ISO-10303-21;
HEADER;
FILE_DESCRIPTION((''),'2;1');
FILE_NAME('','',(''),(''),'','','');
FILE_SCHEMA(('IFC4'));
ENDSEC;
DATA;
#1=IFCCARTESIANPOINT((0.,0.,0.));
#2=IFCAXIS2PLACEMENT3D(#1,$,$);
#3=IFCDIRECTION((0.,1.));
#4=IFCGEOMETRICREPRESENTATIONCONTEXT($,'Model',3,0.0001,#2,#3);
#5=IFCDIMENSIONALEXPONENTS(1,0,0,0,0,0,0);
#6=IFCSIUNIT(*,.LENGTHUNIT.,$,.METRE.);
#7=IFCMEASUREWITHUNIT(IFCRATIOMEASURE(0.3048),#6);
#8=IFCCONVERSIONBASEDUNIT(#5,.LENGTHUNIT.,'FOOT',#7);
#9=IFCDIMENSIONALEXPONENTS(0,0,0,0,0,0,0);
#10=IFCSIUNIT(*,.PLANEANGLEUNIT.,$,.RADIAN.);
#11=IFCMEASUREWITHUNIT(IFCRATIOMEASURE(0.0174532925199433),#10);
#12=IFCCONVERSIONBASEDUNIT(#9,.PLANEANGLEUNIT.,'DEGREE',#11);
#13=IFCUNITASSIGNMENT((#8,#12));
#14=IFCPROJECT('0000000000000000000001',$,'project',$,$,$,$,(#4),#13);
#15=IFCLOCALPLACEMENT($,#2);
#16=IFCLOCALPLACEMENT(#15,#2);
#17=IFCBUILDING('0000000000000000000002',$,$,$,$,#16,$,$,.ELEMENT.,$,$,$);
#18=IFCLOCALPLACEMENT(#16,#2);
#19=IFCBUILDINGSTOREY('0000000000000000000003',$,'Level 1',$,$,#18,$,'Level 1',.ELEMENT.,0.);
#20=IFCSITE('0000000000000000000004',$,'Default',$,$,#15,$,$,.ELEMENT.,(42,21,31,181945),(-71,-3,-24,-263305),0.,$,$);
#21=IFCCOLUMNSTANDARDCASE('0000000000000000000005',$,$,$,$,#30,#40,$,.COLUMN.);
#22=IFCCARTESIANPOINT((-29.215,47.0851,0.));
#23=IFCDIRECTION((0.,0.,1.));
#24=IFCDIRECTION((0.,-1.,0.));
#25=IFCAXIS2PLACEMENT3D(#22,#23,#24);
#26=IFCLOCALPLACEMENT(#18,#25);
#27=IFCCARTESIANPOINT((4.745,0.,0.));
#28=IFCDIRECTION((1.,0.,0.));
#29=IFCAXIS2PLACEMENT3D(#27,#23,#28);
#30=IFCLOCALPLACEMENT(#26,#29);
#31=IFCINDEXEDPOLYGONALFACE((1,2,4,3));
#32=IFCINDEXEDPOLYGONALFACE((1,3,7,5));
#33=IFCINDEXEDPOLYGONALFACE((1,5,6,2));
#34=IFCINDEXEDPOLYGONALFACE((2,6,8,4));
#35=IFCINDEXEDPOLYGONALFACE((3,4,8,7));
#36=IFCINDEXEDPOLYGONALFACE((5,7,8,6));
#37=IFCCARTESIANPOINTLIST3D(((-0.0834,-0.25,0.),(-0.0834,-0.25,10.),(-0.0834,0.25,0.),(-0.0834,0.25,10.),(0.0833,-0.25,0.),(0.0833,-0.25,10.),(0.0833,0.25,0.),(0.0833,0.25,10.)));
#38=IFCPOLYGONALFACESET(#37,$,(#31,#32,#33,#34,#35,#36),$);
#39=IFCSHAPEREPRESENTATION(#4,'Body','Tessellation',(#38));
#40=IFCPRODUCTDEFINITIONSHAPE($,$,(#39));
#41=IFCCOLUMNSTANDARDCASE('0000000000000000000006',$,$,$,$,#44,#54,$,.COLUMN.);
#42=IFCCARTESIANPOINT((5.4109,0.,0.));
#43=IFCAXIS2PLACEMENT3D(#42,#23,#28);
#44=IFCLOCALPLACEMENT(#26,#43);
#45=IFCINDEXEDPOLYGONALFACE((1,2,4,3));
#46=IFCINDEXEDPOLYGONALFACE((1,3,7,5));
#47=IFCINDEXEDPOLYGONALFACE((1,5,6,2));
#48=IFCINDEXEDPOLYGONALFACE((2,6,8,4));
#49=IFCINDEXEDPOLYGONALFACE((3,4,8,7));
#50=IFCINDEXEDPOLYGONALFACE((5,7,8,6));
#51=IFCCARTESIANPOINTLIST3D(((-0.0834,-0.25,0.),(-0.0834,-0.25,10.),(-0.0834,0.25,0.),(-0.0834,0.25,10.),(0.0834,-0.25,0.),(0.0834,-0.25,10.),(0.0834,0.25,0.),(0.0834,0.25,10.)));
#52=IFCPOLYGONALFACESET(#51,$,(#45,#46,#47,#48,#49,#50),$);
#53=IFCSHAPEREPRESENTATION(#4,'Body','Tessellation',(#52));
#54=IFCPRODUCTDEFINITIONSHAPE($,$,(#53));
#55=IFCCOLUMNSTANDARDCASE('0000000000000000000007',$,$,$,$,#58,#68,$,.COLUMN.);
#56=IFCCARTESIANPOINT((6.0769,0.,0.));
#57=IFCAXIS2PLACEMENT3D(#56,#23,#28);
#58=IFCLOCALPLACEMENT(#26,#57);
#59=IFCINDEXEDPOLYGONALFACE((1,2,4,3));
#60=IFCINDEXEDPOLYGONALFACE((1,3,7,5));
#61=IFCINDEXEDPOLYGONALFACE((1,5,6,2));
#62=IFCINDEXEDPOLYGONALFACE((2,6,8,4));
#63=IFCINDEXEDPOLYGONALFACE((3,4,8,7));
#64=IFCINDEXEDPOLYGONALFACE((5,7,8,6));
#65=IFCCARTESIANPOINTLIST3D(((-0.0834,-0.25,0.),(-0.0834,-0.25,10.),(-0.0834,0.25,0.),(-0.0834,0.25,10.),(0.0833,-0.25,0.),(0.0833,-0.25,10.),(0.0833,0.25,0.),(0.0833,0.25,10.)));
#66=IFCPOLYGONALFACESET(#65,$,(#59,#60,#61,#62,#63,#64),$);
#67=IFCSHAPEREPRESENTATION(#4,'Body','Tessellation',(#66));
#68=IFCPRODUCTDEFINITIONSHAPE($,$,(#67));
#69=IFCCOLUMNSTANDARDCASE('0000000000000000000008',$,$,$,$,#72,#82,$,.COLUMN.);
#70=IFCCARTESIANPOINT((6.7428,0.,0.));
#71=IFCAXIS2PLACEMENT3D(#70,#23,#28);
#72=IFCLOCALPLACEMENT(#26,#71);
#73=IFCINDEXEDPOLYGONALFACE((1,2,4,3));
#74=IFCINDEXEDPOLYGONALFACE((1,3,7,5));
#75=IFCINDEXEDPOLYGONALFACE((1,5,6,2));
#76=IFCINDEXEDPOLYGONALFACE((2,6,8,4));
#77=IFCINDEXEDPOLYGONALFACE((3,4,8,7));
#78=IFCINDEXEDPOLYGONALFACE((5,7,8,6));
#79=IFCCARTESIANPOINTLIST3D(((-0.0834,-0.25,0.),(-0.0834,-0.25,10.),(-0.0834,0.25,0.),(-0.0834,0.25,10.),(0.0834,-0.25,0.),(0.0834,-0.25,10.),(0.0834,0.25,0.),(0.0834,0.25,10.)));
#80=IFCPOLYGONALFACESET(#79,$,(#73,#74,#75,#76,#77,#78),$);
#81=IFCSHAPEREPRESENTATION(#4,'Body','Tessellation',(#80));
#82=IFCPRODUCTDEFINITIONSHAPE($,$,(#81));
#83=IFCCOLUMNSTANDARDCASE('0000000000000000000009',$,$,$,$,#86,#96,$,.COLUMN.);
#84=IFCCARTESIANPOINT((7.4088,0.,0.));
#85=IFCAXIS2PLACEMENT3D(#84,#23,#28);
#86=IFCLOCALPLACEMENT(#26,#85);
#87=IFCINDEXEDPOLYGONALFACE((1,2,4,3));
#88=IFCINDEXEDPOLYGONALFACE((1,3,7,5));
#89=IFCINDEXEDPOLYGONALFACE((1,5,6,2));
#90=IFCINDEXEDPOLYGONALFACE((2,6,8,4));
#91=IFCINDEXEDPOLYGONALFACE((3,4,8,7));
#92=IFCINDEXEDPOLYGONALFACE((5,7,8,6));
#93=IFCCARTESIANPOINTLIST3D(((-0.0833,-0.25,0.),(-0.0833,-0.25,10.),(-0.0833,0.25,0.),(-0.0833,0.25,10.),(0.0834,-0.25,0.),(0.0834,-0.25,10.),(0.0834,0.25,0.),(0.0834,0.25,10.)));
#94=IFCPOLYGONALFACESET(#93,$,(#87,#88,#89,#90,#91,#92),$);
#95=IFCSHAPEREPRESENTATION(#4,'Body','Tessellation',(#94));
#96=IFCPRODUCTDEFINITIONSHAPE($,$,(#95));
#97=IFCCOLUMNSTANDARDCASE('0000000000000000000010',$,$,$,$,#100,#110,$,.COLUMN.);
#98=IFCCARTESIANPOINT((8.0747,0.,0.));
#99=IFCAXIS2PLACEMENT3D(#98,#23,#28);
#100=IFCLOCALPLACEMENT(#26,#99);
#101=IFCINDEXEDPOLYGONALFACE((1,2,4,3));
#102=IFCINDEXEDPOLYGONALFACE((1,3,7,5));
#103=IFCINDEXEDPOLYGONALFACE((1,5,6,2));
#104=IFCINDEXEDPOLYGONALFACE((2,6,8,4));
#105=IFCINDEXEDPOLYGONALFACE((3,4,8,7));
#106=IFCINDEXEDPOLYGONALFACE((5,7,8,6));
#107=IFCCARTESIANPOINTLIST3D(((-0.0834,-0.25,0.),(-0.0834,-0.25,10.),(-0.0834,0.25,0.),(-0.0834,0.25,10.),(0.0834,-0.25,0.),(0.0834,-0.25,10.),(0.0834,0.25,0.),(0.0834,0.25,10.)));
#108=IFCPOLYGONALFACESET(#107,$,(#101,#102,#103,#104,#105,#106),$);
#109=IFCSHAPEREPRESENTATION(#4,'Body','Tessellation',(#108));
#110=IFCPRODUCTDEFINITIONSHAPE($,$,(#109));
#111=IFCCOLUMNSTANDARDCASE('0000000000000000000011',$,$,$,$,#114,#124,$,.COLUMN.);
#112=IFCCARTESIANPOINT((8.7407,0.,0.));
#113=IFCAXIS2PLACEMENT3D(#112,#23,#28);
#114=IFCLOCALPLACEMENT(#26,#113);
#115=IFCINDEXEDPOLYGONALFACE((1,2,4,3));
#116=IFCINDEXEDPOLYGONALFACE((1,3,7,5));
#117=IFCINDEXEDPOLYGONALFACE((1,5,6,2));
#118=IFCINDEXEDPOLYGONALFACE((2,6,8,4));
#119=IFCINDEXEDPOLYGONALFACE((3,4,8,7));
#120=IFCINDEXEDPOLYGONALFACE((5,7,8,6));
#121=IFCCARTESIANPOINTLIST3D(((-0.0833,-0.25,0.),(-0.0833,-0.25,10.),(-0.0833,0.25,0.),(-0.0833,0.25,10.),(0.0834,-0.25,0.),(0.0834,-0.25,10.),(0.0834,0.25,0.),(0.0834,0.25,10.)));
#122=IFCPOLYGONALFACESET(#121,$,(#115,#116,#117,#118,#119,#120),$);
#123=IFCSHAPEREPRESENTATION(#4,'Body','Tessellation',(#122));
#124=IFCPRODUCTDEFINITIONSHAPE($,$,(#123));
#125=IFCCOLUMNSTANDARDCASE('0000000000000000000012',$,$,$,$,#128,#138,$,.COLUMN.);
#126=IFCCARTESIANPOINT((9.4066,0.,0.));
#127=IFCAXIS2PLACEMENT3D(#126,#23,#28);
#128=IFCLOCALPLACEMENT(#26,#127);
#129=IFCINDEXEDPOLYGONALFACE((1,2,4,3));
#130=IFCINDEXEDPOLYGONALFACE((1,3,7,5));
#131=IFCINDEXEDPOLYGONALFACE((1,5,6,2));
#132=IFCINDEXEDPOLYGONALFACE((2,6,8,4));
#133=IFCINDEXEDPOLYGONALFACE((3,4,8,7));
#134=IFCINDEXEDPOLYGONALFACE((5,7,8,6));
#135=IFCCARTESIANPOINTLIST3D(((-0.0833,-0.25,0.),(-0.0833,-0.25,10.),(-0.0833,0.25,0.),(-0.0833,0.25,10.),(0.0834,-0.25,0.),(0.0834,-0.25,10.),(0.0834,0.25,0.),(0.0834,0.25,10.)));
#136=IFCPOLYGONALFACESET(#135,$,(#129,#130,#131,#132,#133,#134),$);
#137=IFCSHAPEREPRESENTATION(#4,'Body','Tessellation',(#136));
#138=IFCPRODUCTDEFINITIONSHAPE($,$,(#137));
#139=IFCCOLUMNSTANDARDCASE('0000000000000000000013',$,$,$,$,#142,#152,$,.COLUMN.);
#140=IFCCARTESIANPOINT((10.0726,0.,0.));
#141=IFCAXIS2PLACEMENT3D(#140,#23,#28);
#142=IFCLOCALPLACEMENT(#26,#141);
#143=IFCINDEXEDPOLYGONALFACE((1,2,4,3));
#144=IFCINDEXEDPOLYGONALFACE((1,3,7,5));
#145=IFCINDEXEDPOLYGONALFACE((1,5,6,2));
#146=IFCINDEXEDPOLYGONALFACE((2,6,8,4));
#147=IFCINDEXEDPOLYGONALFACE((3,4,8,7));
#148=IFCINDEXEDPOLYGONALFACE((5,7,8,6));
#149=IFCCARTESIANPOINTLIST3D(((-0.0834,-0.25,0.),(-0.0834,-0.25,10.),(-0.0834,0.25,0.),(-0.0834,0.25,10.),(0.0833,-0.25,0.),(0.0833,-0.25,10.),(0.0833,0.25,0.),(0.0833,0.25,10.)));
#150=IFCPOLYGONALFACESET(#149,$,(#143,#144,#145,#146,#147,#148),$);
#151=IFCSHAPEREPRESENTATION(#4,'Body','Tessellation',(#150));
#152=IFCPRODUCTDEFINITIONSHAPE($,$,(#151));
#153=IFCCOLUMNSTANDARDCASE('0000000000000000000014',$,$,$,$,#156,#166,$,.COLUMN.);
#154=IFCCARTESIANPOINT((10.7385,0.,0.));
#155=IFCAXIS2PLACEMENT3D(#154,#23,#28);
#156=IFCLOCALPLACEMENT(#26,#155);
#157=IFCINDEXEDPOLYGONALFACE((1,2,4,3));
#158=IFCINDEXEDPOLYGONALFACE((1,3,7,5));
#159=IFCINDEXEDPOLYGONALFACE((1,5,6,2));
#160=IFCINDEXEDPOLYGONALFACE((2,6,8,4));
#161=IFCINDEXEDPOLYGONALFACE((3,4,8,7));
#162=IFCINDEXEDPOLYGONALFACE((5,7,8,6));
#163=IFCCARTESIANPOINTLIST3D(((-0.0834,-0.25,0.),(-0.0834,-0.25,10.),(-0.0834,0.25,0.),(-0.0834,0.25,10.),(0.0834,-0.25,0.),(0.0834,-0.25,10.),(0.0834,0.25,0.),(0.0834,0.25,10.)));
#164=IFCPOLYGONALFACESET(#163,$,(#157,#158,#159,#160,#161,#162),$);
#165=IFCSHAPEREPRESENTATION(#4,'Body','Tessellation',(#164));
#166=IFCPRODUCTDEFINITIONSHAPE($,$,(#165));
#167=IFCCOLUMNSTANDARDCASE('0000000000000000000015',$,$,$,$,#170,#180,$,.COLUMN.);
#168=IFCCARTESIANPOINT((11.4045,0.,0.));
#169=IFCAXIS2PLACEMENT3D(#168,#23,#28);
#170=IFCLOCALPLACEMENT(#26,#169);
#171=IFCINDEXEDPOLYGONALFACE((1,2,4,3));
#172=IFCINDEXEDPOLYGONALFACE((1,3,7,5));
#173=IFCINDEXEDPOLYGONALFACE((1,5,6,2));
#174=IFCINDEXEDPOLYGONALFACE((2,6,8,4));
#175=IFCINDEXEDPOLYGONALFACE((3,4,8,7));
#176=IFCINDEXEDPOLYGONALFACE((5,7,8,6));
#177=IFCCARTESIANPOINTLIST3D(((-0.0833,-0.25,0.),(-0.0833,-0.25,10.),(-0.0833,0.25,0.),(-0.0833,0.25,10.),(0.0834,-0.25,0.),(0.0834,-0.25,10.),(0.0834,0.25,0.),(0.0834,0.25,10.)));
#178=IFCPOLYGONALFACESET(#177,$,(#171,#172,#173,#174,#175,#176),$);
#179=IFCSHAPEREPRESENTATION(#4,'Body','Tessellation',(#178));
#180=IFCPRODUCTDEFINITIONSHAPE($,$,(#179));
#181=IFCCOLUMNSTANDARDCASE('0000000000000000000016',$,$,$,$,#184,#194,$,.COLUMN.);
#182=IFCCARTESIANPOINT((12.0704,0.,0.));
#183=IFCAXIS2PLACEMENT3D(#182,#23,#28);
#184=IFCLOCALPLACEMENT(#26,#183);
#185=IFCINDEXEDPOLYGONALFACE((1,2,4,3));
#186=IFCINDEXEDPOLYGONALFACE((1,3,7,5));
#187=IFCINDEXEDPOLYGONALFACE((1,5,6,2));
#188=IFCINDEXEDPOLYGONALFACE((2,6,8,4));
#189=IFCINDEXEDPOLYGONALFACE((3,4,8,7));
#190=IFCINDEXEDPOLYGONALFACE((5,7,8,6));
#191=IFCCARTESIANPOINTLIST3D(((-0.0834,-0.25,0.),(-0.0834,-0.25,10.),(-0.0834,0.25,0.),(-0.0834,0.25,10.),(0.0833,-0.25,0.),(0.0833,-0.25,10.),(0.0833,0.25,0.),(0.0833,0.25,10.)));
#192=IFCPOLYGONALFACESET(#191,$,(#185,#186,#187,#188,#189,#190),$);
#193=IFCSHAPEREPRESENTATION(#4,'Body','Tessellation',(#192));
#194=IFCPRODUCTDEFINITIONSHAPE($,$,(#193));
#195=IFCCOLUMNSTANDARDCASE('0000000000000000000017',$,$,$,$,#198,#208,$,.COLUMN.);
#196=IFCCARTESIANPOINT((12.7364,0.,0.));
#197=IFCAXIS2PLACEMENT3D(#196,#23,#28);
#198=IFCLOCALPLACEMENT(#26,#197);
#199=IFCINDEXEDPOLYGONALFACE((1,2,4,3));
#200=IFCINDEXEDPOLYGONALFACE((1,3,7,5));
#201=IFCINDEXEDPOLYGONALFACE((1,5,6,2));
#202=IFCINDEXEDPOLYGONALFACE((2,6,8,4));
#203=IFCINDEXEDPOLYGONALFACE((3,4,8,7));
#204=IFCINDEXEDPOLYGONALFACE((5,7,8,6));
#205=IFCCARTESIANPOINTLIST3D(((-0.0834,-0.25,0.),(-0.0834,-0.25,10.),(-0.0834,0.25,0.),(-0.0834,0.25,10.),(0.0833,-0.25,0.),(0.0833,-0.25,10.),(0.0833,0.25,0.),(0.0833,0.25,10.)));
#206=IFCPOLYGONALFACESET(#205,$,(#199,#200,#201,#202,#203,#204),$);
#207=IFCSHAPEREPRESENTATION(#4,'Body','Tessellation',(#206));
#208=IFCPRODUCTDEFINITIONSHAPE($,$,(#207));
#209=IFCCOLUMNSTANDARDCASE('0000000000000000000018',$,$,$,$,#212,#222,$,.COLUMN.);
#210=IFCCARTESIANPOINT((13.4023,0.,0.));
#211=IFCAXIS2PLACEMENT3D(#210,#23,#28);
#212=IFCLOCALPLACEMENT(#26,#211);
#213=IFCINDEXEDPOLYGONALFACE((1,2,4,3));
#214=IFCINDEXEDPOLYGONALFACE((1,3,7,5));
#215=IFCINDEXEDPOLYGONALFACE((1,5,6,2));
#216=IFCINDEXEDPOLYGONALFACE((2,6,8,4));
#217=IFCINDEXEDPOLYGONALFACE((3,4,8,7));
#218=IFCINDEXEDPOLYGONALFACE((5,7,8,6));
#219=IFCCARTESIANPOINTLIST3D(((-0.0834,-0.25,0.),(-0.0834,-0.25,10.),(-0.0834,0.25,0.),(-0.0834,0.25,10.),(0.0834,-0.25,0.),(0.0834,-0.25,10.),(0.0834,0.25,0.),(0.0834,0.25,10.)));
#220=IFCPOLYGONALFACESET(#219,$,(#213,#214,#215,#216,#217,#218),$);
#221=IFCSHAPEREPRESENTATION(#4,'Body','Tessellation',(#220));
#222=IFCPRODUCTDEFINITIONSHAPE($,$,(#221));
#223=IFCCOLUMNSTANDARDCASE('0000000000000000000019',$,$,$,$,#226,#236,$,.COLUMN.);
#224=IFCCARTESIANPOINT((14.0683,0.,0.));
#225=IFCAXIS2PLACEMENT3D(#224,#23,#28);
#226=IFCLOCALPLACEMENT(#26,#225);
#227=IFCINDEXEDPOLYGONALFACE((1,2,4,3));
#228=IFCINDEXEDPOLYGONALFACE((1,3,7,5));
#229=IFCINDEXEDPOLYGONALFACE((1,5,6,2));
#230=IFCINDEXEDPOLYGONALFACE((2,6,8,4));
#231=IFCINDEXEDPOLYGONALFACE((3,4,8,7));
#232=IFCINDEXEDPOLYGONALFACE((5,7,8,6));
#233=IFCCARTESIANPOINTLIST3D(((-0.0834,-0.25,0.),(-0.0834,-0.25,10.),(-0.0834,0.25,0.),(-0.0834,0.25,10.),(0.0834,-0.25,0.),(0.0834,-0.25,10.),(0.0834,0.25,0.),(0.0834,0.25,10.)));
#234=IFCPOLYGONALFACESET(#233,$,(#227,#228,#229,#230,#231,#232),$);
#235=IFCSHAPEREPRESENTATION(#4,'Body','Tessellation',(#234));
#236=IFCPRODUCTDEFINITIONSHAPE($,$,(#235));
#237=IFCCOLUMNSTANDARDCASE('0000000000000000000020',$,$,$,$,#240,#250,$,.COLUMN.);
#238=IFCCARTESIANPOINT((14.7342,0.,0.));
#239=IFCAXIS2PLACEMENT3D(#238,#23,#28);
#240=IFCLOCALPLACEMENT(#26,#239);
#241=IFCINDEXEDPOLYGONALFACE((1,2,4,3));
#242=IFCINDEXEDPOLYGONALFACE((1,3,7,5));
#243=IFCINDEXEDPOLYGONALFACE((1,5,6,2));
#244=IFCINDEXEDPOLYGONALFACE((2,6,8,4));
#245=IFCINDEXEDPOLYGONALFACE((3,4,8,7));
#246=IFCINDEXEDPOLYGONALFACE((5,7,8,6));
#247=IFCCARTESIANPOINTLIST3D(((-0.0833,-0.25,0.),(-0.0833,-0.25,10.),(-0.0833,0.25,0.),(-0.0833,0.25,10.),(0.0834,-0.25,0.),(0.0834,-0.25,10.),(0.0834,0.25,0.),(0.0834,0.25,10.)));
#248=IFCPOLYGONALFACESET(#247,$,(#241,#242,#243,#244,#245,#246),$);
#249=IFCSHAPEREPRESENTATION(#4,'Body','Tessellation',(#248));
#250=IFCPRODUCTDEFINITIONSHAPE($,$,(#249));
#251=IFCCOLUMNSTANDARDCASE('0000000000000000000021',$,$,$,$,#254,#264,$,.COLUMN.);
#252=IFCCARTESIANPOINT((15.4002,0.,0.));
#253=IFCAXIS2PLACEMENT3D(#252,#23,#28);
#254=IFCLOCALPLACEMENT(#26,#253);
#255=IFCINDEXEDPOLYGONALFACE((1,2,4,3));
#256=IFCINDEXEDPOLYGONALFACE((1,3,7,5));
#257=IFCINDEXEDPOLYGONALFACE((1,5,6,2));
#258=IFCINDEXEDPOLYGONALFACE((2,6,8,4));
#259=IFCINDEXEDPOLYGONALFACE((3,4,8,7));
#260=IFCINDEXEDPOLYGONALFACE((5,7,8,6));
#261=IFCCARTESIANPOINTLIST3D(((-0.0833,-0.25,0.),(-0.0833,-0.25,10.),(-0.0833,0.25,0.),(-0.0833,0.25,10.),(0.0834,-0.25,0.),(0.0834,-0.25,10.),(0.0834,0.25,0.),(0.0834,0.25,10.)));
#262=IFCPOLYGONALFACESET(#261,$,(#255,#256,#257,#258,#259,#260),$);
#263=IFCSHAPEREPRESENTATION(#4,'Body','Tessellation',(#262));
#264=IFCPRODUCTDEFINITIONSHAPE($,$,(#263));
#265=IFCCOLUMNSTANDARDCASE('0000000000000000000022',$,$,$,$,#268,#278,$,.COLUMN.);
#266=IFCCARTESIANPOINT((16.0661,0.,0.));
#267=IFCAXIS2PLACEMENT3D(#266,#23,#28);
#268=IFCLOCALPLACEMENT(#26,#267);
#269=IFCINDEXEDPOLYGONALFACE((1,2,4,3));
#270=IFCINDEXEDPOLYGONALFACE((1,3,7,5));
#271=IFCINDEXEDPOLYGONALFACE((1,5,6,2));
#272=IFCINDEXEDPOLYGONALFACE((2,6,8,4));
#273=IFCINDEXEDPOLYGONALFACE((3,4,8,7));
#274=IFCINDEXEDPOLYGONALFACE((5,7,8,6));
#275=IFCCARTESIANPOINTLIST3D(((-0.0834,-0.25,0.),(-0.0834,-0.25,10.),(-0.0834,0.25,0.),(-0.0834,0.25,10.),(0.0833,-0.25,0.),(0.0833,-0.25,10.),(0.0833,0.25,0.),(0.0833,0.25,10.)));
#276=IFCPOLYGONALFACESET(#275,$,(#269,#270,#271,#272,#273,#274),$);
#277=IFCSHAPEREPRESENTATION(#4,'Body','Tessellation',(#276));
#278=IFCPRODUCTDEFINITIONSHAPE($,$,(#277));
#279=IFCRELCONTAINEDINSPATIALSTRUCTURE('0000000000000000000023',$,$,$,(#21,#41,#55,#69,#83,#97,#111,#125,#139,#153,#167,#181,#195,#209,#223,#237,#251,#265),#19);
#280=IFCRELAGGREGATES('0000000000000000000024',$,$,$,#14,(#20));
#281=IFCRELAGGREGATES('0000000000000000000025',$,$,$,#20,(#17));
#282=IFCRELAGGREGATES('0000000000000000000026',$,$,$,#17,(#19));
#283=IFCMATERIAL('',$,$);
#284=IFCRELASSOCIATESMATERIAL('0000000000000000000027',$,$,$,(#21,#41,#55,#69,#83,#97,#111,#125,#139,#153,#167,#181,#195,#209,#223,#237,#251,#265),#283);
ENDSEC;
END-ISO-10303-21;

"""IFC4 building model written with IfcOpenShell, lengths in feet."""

from ifc_helpers import new_model, entity, si_unit, converted_unit, direction, frame, origin, place, context, project, spatial, rectangle, extrude, material, element, save


model = new_model("IFC4")

# Units and contexts
model_context = context("Model", 3, precision=0.0001, world=origin(), true_north=direction((0.0, 1.0)))
ifc_project = project(units=[converted_unit("LENGTHUNIT", "FOOT", entity("IfcRatioMeasure", 0.3048), si_unit("LENGTHUNIT", "METRE"), dimensions=[1, 0, 0, 0, 0, 0, 0]), converted_unit("PLANEANGLEUNIT", "DEGREE", entity("IfcRatioMeasure", 0.0174532925199433), si_unit("PLANEANGLEUNIT", "RADIAN"), dimensions=[0, 0, 0, 0, 0, 0, 0])], contexts=[model_context])

# Site, building, storey
site_placement = place(None, origin())
site = spatial("IfcSite", under=ifc_project, at=site_placement, Name="Default", CompositionType="ELEMENT", RefLatitude=(42, 21, 31, 181945), RefLongitude=(-71, -3, -24, -263305), RefElevation=0.0)
building_placement = place(site_placement, origin())
building = spatial("IfcBuilding", under=site, at=building_placement, CompositionType="ELEMENT")
storey_placement = place(building_placement, origin())
storey = spatial("IfcBuildingStorey", under=building, at=storey_placement, Name="Level 1", LongName="Level 1", CompositionType="ELEMENT", Elevation=0.0)

# Columns
ifc_material = material(Name="")
placement = place(storey_placement, frame((-29.215, 47.0851, 0.0), z_axis=(0.0, 0.0, 1.0), x_axis=(0.0, -1.0, 0.0)))
for number, where, z_axis, x_axis in (
    (1, (4.745, 0.0, 0.0), (0.0, 0.0, 1.0), (1.0, 0.0, 0.0)),
    (2, (5.4109, 0.0, 0.0), (0.0, 0.0, 1.0), (1.0, 0.0, 0.0)),
    (3, (6.0769, 0.0, 0.0), (0.0, 0.0, 1.0), (1.0, 0.0, 0.0)),
    (4, (6.7428, 0.0, 0.0), (0.0, 0.0, 1.0), (1.0, 0.0, 0.0)),
    (5, (7.4088, 0.0, 0.0), (0.0, 0.0, 1.0), (1.0, 0.0, 0.0)),
    (6, (8.0747, 0.0, 0.0), (0.0, 0.0, 1.0), (1.0, 0.0, 0.0)),
    (7, (8.7407, 0.0, 0.0), (0.0, 0.0, 1.0), (1.0, 0.0, 0.0)),
    (8, (9.4066, 0.0, 0.0), (0.0, 0.0, 1.0), (1.0, 0.0, 0.0)),
    (9, (10.0726, 0.0, 0.0), (0.0, 0.0, 1.0), (1.0, 0.0, 0.0)),
    (10, (10.7385, 0.0, 0.0), (0.0, 0.0, 1.0), (1.0, 0.0, 0.0)),
    (11, (11.4045, 0.0, 0.0), (0.0, 0.0, 1.0), (1.0, 0.0, 0.0)),
    (12, (12.0704, 0.0, 0.0), (0.0, 0.0, 1.0), (1.0, 0.0, 0.0)),
    (13, (12.7364, 0.0, 0.0), (0.0, 0.0, 1.0), (1.0, 0.0, 0.0)),
    (14, (13.4023, 0.0, 0.0), (0.0, 0.0, 1.0), (1.0, 0.0, 0.0)),
    (15, (14.0683, 0.0, 0.0), (0.0, 0.0, 1.0), (1.0, 0.0, 0.0)),
    (16, (14.7342, 0.0, 0.0), (0.0, 0.0, 1.0), (1.0, 0.0, 0.0)),
    (17, (15.4002, 0.0, 0.0), (0.0, 0.0, 1.0), (1.0, 0.0, 0.0)),
    (18, (16.0661, 0.0, 0.0), (0.0, 0.0, 1.0), (1.0, 0.0, 0.0)),
):
    element("IfcColumnStandardCase", number, at=place(placement, frame(where, z_axis=z_axis, x_axis=x_axis)), inside=storey, material=ifc_material, PredefinedType="COLUMN", context=model_context, shape_type="SweptSolid", body=[
        extrude(rectangle(XDim=0.1667, YDim=0.5), origin(), (0.0, 0.0, 1.0), 10.0),
    ])

save(model, "model.ifc")
